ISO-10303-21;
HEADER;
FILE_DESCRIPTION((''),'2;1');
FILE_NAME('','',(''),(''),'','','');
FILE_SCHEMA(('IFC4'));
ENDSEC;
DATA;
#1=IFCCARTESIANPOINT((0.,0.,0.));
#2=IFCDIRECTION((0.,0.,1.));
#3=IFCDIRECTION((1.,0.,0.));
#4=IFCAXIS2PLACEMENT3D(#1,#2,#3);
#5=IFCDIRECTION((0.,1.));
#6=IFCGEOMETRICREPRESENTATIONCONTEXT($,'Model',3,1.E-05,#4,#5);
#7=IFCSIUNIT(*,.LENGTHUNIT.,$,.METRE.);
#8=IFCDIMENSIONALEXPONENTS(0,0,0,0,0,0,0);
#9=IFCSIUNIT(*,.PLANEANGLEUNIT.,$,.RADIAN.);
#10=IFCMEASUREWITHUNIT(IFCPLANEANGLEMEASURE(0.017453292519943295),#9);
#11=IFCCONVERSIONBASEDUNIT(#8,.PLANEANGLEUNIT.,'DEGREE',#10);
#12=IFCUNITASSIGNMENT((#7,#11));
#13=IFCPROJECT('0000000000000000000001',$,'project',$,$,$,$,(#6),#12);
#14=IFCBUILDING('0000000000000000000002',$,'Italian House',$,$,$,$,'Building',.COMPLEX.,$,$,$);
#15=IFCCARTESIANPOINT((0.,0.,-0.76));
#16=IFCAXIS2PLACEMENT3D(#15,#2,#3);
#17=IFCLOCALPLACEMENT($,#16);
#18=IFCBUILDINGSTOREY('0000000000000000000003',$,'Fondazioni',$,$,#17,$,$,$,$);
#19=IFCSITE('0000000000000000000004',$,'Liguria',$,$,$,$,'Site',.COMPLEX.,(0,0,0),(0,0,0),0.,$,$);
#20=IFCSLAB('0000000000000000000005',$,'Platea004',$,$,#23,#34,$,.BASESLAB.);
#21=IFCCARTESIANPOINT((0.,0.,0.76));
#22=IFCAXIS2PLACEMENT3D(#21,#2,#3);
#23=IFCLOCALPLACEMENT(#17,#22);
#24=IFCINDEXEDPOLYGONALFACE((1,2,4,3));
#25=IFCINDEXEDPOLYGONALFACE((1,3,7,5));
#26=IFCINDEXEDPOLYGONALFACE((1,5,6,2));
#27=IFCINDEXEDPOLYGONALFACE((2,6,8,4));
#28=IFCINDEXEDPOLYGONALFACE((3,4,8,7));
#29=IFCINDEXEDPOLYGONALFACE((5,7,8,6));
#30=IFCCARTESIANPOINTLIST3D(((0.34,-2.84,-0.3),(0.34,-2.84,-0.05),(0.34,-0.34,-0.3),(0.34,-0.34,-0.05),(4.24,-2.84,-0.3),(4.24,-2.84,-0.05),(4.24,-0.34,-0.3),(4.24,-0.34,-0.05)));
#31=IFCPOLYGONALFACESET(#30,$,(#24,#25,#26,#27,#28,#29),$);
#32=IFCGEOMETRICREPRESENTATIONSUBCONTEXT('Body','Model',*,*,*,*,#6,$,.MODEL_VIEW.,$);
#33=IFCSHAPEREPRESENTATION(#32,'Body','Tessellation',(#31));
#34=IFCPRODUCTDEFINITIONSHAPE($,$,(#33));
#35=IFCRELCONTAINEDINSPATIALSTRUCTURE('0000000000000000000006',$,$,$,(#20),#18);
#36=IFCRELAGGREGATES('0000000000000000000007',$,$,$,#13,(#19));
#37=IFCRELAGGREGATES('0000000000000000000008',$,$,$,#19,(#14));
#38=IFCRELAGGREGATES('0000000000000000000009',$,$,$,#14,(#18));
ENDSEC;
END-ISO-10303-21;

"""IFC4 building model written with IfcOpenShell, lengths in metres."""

from ifc_helpers import new_model, entity, si_unit, converted_unit, direction, frame, origin_with_axes, origin_2d_with_axis, place, context, subcontext, project, spatial, rectangle, extrude, element, save


model = new_model("IFC4")

# Units and contexts
model_context = context("Model", 3, precision=1e-05, world=origin_with_axes(), true_north=direction((0.0, 1.0)))
body_context = subcontext(model_context, "Body", "Model", "MODEL_VIEW")
ifc_project = project(units=[si_unit("LENGTHUNIT", "METRE"), converted_unit("PLANEANGLEUNIT", "DEGREE", entity("IfcPlaneAngleMeasure", 0.017453292519943295), si_unit("PLANEANGLEUNIT", "RADIAN"), dimensions=[0, 0, 0, 0, 0, 0, 0])], contexts=[model_context])

# Site, building, storey
site = spatial("IfcSite", under=ifc_project, Name="Liguria", LongName="Site", CompositionType="COMPLEX", RefLatitude=(0, 0, 0), RefLongitude=(0, 0, 0), RefElevation=0.0)
building = spatial("IfcBuilding", under=site, Name="Italian House", LongName="Building", CompositionType="COMPLEX")
storey_placement = place(None, frame((0.0, 0.0, -0.76), z_axis=(0.0, 0.0, 1.0), x_axis=(1.0, 0.0, 0.0)))
storey = spatial("IfcBuildingStorey", under=building, at=storey_placement, Name="Fondazioni")

# Slab
slab_1_placement = place(storey_placement, frame((0.0, 0.0, 0.76), z_axis=(0.0, 0.0, 1.0), x_axis=(1.0, 0.0, 0.0)))
element("IfcSlab", 1, at=slab_1_placement, inside=storey, Name="Platea004", PredefinedType="BASESLAB", context=body_context, shape_type="SweptSolid", body=[
    extrude(rectangle(XDim=3.9, YDim=2.5, at=origin_2d_with_axis()), frame((2.29, -1.59, -0.05), z_axis=(0.0, 0.0, 1.0), x_axis=(1.0, 0.0, 0.0)), (0.0, 0.0, -1.0), 0.25),
])

save(model, "model.ifc")
